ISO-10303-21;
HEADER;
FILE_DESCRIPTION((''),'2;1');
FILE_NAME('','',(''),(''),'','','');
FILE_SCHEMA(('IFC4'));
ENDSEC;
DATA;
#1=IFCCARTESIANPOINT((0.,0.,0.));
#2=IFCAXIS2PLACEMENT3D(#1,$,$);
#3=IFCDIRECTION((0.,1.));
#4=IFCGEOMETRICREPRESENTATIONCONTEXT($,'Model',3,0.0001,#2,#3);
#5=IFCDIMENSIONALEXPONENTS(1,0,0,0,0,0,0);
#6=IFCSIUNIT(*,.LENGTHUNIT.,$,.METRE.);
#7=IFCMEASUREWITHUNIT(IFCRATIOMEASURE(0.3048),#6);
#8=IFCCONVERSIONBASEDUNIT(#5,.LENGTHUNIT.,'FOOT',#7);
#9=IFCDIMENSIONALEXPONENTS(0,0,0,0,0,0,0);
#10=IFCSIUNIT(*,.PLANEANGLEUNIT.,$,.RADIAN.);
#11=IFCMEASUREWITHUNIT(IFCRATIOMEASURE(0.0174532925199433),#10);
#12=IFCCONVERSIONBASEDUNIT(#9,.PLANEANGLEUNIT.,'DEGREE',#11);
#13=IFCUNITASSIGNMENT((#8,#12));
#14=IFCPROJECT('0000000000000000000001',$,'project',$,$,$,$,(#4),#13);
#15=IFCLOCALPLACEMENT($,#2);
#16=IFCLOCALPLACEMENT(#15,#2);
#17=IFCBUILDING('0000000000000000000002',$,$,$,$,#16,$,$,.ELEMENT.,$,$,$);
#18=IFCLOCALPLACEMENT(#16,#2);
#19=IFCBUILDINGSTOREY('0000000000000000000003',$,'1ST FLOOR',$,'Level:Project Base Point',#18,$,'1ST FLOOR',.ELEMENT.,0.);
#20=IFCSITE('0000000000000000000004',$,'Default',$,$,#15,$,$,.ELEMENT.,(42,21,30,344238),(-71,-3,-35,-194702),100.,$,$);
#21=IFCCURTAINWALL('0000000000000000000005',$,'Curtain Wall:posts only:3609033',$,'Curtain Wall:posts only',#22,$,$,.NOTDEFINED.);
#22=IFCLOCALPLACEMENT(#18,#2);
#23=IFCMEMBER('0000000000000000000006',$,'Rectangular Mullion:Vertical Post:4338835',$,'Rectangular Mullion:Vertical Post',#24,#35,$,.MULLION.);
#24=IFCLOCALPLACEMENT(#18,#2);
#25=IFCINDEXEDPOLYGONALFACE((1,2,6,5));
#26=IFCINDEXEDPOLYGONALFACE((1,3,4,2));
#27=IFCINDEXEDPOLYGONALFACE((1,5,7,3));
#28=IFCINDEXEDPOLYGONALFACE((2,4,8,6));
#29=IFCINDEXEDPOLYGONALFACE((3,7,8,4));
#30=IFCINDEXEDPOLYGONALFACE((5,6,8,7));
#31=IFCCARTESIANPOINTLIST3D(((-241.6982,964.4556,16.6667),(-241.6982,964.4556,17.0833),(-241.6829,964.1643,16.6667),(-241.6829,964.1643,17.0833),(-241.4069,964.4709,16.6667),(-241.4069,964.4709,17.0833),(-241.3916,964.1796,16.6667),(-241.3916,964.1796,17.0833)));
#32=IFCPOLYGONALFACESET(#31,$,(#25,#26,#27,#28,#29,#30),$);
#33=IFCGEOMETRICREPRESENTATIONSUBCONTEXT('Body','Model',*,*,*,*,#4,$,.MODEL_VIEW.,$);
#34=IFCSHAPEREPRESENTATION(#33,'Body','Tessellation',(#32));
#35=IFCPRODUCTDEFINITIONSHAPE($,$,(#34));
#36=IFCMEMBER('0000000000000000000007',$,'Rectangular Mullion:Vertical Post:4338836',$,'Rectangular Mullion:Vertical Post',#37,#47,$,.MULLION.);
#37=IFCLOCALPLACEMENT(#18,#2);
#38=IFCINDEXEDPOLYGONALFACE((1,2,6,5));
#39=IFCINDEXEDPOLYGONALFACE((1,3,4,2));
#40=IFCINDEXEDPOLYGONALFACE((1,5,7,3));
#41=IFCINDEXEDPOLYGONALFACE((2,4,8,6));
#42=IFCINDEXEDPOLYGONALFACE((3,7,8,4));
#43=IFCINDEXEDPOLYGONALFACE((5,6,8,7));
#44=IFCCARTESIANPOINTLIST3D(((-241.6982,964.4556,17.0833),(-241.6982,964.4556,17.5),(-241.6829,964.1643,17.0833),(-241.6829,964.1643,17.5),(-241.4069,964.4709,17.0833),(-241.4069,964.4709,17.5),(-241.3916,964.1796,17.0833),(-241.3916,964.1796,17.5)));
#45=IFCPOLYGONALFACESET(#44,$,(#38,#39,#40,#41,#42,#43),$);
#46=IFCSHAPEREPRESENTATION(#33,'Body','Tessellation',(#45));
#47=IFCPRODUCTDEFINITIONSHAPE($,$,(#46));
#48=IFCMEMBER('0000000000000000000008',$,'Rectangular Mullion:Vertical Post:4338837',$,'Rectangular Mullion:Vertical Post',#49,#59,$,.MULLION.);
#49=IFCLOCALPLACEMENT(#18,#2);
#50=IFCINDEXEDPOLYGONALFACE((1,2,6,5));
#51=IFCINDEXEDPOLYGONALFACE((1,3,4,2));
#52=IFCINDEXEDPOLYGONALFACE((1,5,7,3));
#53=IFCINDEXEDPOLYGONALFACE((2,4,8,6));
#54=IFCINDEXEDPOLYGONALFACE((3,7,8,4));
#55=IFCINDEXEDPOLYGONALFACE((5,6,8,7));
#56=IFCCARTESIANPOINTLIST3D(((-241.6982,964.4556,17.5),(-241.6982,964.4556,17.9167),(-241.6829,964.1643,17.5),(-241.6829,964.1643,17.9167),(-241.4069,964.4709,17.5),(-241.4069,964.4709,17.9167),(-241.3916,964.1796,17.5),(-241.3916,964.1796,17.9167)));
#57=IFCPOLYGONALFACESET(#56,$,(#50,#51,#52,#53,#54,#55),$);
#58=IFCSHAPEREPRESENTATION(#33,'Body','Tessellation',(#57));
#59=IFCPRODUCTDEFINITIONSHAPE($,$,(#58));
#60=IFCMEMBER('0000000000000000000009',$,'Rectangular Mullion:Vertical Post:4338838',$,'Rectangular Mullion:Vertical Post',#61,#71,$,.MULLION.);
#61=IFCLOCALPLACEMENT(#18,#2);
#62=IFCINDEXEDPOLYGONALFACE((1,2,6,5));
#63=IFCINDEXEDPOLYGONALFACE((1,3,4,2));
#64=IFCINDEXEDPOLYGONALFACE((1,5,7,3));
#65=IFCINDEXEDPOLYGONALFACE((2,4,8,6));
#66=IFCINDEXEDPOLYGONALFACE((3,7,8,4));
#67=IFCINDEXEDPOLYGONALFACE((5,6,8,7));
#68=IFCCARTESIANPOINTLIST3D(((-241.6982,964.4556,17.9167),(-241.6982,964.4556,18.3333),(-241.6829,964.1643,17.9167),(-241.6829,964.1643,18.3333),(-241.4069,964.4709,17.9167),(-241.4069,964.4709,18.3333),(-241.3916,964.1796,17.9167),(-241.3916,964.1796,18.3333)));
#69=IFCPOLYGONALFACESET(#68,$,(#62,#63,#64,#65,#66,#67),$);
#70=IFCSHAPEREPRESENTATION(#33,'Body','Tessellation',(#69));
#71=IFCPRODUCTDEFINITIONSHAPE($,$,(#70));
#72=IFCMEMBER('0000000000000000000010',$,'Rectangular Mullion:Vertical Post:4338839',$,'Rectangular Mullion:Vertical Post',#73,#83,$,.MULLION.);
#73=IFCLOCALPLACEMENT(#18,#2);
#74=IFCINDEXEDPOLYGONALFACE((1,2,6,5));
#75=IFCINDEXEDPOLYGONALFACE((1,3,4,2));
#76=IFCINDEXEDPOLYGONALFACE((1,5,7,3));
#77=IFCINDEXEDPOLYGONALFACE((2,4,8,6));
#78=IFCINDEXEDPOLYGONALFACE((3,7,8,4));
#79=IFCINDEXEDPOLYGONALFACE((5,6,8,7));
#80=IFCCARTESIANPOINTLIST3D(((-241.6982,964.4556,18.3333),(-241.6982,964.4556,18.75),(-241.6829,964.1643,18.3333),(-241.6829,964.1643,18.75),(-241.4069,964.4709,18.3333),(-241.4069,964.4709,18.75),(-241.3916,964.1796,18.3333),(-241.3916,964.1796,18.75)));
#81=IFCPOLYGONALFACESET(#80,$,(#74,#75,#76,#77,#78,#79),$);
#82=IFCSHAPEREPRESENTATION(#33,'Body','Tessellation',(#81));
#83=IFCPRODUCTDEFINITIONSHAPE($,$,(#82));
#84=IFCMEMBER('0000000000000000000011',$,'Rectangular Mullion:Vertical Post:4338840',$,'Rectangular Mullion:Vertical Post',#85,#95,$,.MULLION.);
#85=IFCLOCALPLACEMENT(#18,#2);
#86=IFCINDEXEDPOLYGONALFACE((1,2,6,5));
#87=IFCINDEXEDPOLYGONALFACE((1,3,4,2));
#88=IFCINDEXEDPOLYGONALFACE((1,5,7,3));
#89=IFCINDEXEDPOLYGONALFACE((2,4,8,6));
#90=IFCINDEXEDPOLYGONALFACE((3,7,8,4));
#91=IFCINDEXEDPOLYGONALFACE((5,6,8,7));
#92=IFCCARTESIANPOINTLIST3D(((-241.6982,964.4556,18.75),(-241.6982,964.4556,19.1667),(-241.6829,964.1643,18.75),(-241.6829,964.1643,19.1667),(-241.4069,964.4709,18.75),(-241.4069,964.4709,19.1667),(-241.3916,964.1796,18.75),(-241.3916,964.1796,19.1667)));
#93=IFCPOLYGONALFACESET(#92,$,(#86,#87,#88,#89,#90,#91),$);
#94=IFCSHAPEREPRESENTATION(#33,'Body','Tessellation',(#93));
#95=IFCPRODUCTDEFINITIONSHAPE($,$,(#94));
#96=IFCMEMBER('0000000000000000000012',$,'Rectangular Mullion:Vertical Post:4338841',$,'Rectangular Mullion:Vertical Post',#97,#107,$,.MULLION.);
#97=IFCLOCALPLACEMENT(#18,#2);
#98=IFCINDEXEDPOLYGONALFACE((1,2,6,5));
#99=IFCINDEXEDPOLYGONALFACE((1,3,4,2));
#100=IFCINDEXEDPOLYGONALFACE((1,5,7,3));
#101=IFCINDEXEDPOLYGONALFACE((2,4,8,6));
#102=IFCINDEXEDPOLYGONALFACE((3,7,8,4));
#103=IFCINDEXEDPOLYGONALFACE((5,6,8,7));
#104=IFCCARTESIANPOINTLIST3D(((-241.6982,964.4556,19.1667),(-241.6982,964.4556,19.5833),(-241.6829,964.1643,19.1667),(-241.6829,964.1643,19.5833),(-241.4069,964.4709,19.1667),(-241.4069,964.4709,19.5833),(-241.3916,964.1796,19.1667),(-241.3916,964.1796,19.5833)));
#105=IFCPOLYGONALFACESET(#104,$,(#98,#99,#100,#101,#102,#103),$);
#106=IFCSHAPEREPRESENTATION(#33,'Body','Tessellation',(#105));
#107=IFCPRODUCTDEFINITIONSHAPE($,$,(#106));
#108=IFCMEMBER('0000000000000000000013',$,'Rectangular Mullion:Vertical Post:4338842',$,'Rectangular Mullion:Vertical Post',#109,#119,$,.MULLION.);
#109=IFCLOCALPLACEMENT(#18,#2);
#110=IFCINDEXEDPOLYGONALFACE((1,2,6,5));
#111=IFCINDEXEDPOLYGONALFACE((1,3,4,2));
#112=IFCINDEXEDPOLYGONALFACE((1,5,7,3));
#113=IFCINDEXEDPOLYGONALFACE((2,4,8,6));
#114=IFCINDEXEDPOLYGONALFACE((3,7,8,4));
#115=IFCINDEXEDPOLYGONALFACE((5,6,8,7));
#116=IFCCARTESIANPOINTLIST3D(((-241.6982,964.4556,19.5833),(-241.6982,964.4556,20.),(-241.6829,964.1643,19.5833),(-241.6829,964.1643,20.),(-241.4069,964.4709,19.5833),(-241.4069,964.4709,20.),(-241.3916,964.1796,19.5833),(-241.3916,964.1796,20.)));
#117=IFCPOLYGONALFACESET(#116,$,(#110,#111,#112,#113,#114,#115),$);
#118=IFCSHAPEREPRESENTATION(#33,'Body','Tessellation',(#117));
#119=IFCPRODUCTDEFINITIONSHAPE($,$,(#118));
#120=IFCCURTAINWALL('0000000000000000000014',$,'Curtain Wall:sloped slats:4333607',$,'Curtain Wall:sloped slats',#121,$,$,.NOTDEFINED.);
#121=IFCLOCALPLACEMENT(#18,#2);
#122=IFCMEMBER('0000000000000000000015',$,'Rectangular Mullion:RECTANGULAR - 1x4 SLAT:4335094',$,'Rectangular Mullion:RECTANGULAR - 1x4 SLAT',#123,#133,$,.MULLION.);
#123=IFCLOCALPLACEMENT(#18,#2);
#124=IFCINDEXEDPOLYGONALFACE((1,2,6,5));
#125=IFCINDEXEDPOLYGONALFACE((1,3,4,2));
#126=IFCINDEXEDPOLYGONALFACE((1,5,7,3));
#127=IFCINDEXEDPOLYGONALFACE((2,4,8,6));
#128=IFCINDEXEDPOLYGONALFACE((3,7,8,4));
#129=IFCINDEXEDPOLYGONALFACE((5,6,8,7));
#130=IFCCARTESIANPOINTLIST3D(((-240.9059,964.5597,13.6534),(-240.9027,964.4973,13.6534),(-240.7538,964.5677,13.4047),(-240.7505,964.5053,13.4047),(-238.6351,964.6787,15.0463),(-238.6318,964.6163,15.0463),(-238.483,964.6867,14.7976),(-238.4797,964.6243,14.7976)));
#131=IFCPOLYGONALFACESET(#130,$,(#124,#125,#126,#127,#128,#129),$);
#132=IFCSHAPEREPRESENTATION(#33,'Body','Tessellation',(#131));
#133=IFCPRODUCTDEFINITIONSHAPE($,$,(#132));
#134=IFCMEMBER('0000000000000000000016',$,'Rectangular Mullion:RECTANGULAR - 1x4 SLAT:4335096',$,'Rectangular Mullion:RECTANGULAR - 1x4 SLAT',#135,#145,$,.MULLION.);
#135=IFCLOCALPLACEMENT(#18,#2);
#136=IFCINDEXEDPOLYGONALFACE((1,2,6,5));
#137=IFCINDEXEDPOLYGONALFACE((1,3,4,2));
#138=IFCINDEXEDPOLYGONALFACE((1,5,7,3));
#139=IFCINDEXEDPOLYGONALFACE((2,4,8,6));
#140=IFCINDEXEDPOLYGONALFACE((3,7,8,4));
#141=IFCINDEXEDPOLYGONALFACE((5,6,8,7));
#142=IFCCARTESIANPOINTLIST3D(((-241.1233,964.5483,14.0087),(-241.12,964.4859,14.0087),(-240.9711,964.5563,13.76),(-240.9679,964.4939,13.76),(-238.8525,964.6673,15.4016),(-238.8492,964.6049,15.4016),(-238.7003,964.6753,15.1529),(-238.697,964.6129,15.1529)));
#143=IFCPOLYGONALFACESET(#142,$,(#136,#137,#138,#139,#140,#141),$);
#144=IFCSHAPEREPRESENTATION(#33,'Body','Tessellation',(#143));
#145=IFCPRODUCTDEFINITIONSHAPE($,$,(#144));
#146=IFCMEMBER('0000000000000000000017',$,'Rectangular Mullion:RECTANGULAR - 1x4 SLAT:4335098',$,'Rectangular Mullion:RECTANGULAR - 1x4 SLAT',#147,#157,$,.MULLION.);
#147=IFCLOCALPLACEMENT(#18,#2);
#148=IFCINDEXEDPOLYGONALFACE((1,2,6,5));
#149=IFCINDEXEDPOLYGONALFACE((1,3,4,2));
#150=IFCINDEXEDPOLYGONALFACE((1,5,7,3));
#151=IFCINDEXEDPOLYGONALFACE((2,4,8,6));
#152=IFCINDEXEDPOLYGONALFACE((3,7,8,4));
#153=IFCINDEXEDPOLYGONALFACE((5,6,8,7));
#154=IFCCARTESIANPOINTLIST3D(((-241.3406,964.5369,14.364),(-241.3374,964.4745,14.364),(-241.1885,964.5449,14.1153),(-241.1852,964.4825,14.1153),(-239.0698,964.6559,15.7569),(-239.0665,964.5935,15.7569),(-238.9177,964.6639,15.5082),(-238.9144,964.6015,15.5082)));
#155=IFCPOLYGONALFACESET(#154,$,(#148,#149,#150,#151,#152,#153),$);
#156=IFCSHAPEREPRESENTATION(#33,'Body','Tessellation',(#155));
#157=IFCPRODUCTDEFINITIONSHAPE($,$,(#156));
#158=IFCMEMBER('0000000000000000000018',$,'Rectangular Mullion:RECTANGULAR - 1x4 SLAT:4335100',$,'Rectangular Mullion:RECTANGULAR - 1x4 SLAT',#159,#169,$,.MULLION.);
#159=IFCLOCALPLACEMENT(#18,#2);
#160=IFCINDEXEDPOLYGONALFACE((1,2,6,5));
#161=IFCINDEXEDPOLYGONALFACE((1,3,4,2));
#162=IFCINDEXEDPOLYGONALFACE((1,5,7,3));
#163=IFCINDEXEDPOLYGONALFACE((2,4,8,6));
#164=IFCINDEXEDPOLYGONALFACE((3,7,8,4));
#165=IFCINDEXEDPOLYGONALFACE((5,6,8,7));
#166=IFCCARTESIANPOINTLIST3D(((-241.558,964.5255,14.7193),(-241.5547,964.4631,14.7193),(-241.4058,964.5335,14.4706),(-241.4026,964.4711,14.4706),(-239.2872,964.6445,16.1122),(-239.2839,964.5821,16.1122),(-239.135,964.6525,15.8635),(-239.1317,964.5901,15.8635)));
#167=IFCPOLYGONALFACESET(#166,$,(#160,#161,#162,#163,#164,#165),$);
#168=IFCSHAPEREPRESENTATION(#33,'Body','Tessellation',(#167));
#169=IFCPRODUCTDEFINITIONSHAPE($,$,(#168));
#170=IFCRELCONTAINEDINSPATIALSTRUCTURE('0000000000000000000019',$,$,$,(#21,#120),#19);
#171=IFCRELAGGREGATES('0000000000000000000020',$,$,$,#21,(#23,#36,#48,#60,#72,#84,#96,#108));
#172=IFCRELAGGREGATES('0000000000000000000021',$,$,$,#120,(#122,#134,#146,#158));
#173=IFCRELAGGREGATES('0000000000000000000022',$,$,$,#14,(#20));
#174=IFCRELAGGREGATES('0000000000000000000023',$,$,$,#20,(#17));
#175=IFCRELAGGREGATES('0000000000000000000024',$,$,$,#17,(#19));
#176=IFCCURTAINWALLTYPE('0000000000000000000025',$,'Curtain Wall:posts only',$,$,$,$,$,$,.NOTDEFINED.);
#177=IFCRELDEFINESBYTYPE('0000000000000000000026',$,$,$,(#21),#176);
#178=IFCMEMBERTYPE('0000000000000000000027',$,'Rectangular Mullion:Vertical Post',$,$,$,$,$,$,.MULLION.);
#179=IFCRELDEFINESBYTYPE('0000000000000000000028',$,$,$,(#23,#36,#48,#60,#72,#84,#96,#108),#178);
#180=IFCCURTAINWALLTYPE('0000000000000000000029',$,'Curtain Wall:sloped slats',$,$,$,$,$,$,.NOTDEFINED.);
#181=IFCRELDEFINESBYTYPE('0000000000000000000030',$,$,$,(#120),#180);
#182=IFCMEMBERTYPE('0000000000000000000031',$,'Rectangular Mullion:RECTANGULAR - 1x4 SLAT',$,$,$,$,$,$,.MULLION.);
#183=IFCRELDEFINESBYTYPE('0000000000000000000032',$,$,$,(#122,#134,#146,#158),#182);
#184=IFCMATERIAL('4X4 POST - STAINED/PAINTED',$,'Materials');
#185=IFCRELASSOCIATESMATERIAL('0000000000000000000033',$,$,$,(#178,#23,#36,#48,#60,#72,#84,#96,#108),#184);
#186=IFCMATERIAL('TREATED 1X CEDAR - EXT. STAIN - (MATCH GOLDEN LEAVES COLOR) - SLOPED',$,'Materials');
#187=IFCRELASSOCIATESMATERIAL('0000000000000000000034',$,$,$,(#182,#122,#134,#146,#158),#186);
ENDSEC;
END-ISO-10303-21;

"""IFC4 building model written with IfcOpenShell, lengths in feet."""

from ifc_helpers import new_model, entity, si_unit, converted_unit, direction, frame, frame_2d, origin, origin_2d_with_axis, place, context, subcontext, project, spatial, rectangle, extrude, source, transform, mapped, material, material_profile, profile_set, profile_usage, type_object, type_shapes, element, aggregate, save


model = new_model("IFC4")

# Units and contexts
model_context = context("Model", 3, precision=0.0001, world=origin(), true_north=direction((0.0, 1.0)))
body_context = subcontext(model_context, "Body", "Model", "MODEL_VIEW")
ifc_project = project(units=[converted_unit("LENGTHUNIT", "FOOT", entity("IfcRatioMeasure", 0.3048), si_unit("LENGTHUNIT", "METRE"), dimensions=[1, 0, 0, 0, 0, 0, 0]), converted_unit("PLANEANGLEUNIT", "DEGREE", entity("IfcRatioMeasure", 0.0174532925199433), si_unit("PLANEANGLEUNIT", "RADIAN"), dimensions=[0, 0, 0, 0, 0, 0, 0])], contexts=[model_context])

# Site, building, storey
site_placement = place(None, origin())
site = spatial("IfcSite", under=ifc_project, at=site_placement, Name="Default", CompositionType="ELEMENT", RefLatitude=(42, 21, 30, 344238), RefLongitude=(-71, -3, -35, -194702), RefElevation=100.0)
building_placement = place(site_placement, origin())
building = spatial("IfcBuilding", under=site, at=building_placement, CompositionType="ELEMENT")
storey_placement = place(building_placement, origin())
storey = spatial("IfcBuildingStorey", under=building, at=storey_placement, Name="1ST FLOOR", ObjectType="Level:Project Base Point", LongName="1ST FLOOR", CompositionType="ELEMENT", Elevation=0.0)

# Curtain walls, members
curtain_wall_type_1 = type_object("IfcCurtainWallType", Name="Curtain Wall:posts only", PredefinedType="NOTDEFINED")
curtain_wall_1_placement = place(storey_placement, origin())
curtain_wall_1 = element("IfcCurtainWall", 1, at=curtain_wall_1_placement, inside=storey, type_object=curtain_wall_type_1, Name="Curtain Wall:posts only:3609033", ObjectType="Curtain Wall:posts only", PredefinedType="NOTDEFINED")
ifc_material_1 = material(Name="4X4 POST - STAINED/PAINTED", Category="Materials")
ifc_material_profile_1 = material_profile(ifc_material_1, rectangle(XDim=0.2917, YDim=0.2917, at=origin_2d_with_axis()), Name="Vertical Post")
ifc_profile_set_1 = profile_set([ifc_material_profile_1], Name="Vertical Post")
ifc_profile_usage_1 = profile_usage(ifc_profile_set_1)
member_type_1 = type_object("IfcMemberType", Name="Rectangular Mullion:Vertical Post", PredefinedType="MULLION", material=ifc_profile_set_1)
shared_shape_1 = source(origin(), body_context, "Body", "SweptSolid", [
    extrude(rectangle(XDim=0.2917, YDim=0.2917, at=origin_2d_with_axis()), frame((0.0, -0.2083, -0.4167), z_axis=(0.0, 0.0, 1.0), x_axis=(0.0, -1.0, 0.0)), (0.0, 0.0, 1.0), 0.4167),
])
type_shapes(member_type_1, [shared_shape_1])
member_1_placement = place(storey_placement, frame((-241.5558, 964.5256, 16.6667), z_axis=(0.0, 0.0, -1.0), x_axis=(-0.99863, -0.052336, 0.0)))
member_1 = element("IfcMember", 2, at=member_1_placement, type_object=member_type_1, material=ifc_profile_usage_1, Name="Rectangular Mullion:Vertical Post:4338835", ObjectType="Rectangular Mullion:Vertical Post", PredefinedType="MULLION", context=body_context, shape_type="MappedRepresentation", body=[
    mapped(shared_shape_1, transform((0.0, 0.0, 0.0), scale=1.0)),
])
ifc_profile_usage_2 = profile_usage(ifc_profile_set_1)
member_2_placement = place(storey_placement, frame((-241.5558, 964.5256, 17.0833), z_axis=(0.0, 0.0, -1.0), x_axis=(-0.99863, -0.052336, 0.0)))
member_2 = element("IfcMember", 3, at=member_2_placement, type_object=member_type_1, material=ifc_profile_usage_2, Name="Rectangular Mullion:Vertical Post:4338836", ObjectType="Rectangular Mullion:Vertical Post", PredefinedType="MULLION", context=body_context, shape_type="MappedRepresentation", body=[
    mapped(shared_shape_1, transform((0.0, 0.0, 0.0), scale=1.0)),
])
ifc_profile_usage_3 = profile_usage(ifc_profile_set_1)
member_3_placement = place(storey_placement, frame((-241.5558, 964.5256, 17.5), z_axis=(0.0, 0.0, -1.0), x_axis=(-0.99863, -0.052336, 0.0)))
member_3 = element("IfcMember", 4, at=member_3_placement, type_object=member_type_1, material=ifc_profile_usage_3, Name="Rectangular Mullion:Vertical Post:4338837", ObjectType="Rectangular Mullion:Vertical Post", PredefinedType="MULLION", context=body_context, shape_type="MappedRepresentation", body=[
    mapped(shared_shape_1, transform((0.0, 0.0, 0.0), scale=1.0)),
])
ifc_profile_usage_4 = profile_usage(ifc_profile_set_1)
member_4_placement = place(storey_placement, frame((-241.5558, 964.5256, 17.9167), z_axis=(0.0, 0.0, -1.0), x_axis=(-0.99863, -0.052336, 0.0)))
member_4 = element("IfcMember", 5, at=member_4_placement, type_object=member_type_1, material=ifc_profile_usage_4, Name="Rectangular Mullion:Vertical Post:4338838", ObjectType="Rectangular Mullion:Vertical Post", PredefinedType="MULLION", context=body_context, shape_type="MappedRepresentation", body=[
    mapped(shared_shape_1, transform((0.0, 0.0, 0.0), scale=1.0)),
])
ifc_profile_usage_5 = profile_usage(ifc_profile_set_1)
member_5_placement = place(storey_placement, frame((-241.5558, 964.5256, 18.3333), z_axis=(0.0, 0.0, -1.0), x_axis=(-0.99863, -0.052336, 0.0)))
member_5 = element("IfcMember", 6, at=member_5_placement, type_object=member_type_1, material=ifc_profile_usage_5, Name="Rectangular Mullion:Vertical Post:4338839", ObjectType="Rectangular Mullion:Vertical Post", PredefinedType="MULLION", context=body_context, shape_type="MappedRepresentation", body=[
    mapped(shared_shape_1, transform((0.0, 0.0, 0.0), scale=1.0)),
])
ifc_profile_usage_6 = profile_usage(ifc_profile_set_1)
member_6_placement = place(storey_placement, frame((-241.5558, 964.5256, 18.75), z_axis=(0.0, 0.0, -1.0), x_axis=(-0.99863, -0.052336, 0.0)))
member_6 = element("IfcMember", 7, at=member_6_placement, type_object=member_type_1, material=ifc_profile_usage_6, Name="Rectangular Mullion:Vertical Post:4338840", ObjectType="Rectangular Mullion:Vertical Post", PredefinedType="MULLION", context=body_context, shape_type="MappedRepresentation", body=[
    mapped(shared_shape_1, transform((0.0, 0.0, 0.0), scale=1.0)),
])
ifc_profile_usage_7 = profile_usage(ifc_profile_set_1)
member_7_placement = place(storey_placement, frame((-241.5558, 964.5256, 19.1667), z_axis=(0.0, 0.0, -1.0), x_axis=(-0.99863, -0.052336, 0.0)))
member_7 = element("IfcMember", 8, at=member_7_placement, type_object=member_type_1, material=ifc_profile_usage_7, Name="Rectangular Mullion:Vertical Post:4338841", ObjectType="Rectangular Mullion:Vertical Post", PredefinedType="MULLION", context=body_context, shape_type="MappedRepresentation", body=[
    mapped(shared_shape_1, transform((0.0, 0.0, 0.0), scale=1.0)),
])
ifc_profile_usage_8 = profile_usage(ifc_profile_set_1)
member_8_placement = place(storey_placement, frame((-241.5558, 964.5256, 19.5833), z_axis=(0.0, 0.0, -1.0), x_axis=(-0.99863, -0.052336, 0.0)))
member_8 = element("IfcMember", 9, at=member_8_placement, type_object=member_type_1, material=ifc_profile_usage_8, Name="Rectangular Mullion:Vertical Post:4338842", ObjectType="Rectangular Mullion:Vertical Post", PredefinedType="MULLION", context=body_context, shape_type="MappedRepresentation", body=[
    mapped(shared_shape_1, transform((0.0, 0.0, 0.0), scale=1.0)),
])
aggregate(curtain_wall_1, [member_1, member_2, member_3, member_4, member_5, member_6, member_7, member_8])
curtain_wall_type_2 = type_object("IfcCurtainWallType", Name="Curtain Wall:sloped slats", PredefinedType="NOTDEFINED")
curtain_wall_2_placement = place(storey_placement, origin())
curtain_wall_2 = element("IfcCurtainWall", 10, at=curtain_wall_2_placement, inside=storey, type_object=curtain_wall_type_2, Name="Curtain Wall:sloped slats:4333607", ObjectType="Curtain Wall:sloped slats", PredefinedType="NOTDEFINED")
ifc_material_2 = material(Name="TREATED 1X CEDAR - EXT. STAIN - (MATCH GOLDEN LEAVES COLOR) - SLOPED", Category="Materials")
ifc_material_profile_2 = material_profile(ifc_material_2, rectangle(XDim=0.0625, YDim=0.2917, at=frame_2d((0.0, 0.0), x_axis=(1.0, 0.0))), Name="RECTANGULAR - 1x4 SLAT")
ifc_profile_set_2 = profile_set([ifc_material_profile_2], Name="RECTANGULAR - 1x4 SLAT")
ifc_profile_usage_9 = profile_usage(ifc_profile_set_2)
member_type_2 = type_object("IfcMemberType", Name="Rectangular Mullion:RECTANGULAR - 1x4 SLAT", PredefinedType="MULLION", material=ifc_profile_set_2)
shared_shape_2 = source(origin(), body_context, "Body", "SweptSolid", [
    extrude(rectangle(XDim=0.0625, YDim=0.2917, at=frame_2d((0.0, 0.0), x_axis=(1.0, 0.0))), frame((0.0, 0.0, -2.6667), z_axis=(0.0, 0.0, 1.0), x_axis=(0.0, -1.0, 0.0)), (0.0, 0.0, 1.0), 2.6667),
])
type_shapes(member_type_2, [shared_shape_2])
member_9_placement = place(storey_placement, frame((-240.8282, 964.5325, 13.529), z_axis=(-0.851559, -0.044628, -0.522356), x_axis=(-0.52164, -0.027338, 0.852727)))
member_9 = element("IfcMember", 11, at=member_9_placement, type_object=member_type_2, material=ifc_profile_usage_9, Name="Rectangular Mullion:RECTANGULAR - 1x4 SLAT:4335094", ObjectType="Rectangular Mullion:RECTANGULAR - 1x4 SLAT", PredefinedType="MULLION", context=body_context, shape_type="MappedRepresentation", body=[
    mapped(shared_shape_2, transform((0.0, 0.0, 0.0), scale=1.0)),
])
ifc_profile_usage_10 = profile_usage(ifc_profile_set_2)
member_10_placement = place(storey_placement, frame((-241.0456, 964.5211, 13.8843), z_axis=(-0.851559, -0.044628, -0.522356), x_axis=(-0.52164, -0.027338, 0.852727)))
member_10 = element("IfcMember", 12, at=member_10_placement, type_object=member_type_2, material=ifc_profile_usage_10, Name="Rectangular Mullion:RECTANGULAR - 1x4 SLAT:4335096", ObjectType="Rectangular Mullion:RECTANGULAR - 1x4 SLAT", PredefinedType="MULLION", context=body_context, shape_type="MappedRepresentation", body=[
    mapped(shared_shape_2, transform((0.0, 0.0, 0.0), scale=1.0)),
])
ifc_profile_usage_11 = profile_usage(ifc_profile_set_2)
member_11_placement = place(storey_placement, frame((-241.2629, 964.5097, 14.2396), z_axis=(-0.851559, -0.044628, -0.522356), x_axis=(-0.52164, -0.027338, 0.852727)))
member_11 = element("IfcMember", 13, at=member_11_placement, type_object=member_type_2, material=ifc_profile_usage_11, Name="Rectangular Mullion:RECTANGULAR - 1x4 SLAT:4335098", ObjectType="Rectangular Mullion:RECTANGULAR - 1x4 SLAT", PredefinedType="MULLION", context=body_context, shape_type="MappedRepresentation", body=[
    mapped(shared_shape_2, transform((0.0, 0.0, 0.0), scale=1.0)),
])
ifc_profile_usage_12 = profile_usage(ifc_profile_set_2)
member_12_placement = place(storey_placement, frame((-241.4803, 964.4983, 14.5949), z_axis=(-0.851559, -0.044628, -0.522356), x_axis=(-0.52164, -0.027338, 0.852727)))
member_12 = element("IfcMember", 14, at=member_12_placement, type_object=member_type_2, material=ifc_profile_usage_12, Name="Rectangular Mullion:RECTANGULAR - 1x4 SLAT:4335100", ObjectType="Rectangular Mullion:RECTANGULAR - 1x4 SLAT", PredefinedType="MULLION", context=body_context, shape_type="MappedRepresentation", body=[
    mapped(shared_shape_2, transform((0.0, 0.0, 0.0), scale=1.0)),
])
aggregate(curtain_wall_2, [member_9, member_10, member_11, member_12])

save(model, "model.ifc")
